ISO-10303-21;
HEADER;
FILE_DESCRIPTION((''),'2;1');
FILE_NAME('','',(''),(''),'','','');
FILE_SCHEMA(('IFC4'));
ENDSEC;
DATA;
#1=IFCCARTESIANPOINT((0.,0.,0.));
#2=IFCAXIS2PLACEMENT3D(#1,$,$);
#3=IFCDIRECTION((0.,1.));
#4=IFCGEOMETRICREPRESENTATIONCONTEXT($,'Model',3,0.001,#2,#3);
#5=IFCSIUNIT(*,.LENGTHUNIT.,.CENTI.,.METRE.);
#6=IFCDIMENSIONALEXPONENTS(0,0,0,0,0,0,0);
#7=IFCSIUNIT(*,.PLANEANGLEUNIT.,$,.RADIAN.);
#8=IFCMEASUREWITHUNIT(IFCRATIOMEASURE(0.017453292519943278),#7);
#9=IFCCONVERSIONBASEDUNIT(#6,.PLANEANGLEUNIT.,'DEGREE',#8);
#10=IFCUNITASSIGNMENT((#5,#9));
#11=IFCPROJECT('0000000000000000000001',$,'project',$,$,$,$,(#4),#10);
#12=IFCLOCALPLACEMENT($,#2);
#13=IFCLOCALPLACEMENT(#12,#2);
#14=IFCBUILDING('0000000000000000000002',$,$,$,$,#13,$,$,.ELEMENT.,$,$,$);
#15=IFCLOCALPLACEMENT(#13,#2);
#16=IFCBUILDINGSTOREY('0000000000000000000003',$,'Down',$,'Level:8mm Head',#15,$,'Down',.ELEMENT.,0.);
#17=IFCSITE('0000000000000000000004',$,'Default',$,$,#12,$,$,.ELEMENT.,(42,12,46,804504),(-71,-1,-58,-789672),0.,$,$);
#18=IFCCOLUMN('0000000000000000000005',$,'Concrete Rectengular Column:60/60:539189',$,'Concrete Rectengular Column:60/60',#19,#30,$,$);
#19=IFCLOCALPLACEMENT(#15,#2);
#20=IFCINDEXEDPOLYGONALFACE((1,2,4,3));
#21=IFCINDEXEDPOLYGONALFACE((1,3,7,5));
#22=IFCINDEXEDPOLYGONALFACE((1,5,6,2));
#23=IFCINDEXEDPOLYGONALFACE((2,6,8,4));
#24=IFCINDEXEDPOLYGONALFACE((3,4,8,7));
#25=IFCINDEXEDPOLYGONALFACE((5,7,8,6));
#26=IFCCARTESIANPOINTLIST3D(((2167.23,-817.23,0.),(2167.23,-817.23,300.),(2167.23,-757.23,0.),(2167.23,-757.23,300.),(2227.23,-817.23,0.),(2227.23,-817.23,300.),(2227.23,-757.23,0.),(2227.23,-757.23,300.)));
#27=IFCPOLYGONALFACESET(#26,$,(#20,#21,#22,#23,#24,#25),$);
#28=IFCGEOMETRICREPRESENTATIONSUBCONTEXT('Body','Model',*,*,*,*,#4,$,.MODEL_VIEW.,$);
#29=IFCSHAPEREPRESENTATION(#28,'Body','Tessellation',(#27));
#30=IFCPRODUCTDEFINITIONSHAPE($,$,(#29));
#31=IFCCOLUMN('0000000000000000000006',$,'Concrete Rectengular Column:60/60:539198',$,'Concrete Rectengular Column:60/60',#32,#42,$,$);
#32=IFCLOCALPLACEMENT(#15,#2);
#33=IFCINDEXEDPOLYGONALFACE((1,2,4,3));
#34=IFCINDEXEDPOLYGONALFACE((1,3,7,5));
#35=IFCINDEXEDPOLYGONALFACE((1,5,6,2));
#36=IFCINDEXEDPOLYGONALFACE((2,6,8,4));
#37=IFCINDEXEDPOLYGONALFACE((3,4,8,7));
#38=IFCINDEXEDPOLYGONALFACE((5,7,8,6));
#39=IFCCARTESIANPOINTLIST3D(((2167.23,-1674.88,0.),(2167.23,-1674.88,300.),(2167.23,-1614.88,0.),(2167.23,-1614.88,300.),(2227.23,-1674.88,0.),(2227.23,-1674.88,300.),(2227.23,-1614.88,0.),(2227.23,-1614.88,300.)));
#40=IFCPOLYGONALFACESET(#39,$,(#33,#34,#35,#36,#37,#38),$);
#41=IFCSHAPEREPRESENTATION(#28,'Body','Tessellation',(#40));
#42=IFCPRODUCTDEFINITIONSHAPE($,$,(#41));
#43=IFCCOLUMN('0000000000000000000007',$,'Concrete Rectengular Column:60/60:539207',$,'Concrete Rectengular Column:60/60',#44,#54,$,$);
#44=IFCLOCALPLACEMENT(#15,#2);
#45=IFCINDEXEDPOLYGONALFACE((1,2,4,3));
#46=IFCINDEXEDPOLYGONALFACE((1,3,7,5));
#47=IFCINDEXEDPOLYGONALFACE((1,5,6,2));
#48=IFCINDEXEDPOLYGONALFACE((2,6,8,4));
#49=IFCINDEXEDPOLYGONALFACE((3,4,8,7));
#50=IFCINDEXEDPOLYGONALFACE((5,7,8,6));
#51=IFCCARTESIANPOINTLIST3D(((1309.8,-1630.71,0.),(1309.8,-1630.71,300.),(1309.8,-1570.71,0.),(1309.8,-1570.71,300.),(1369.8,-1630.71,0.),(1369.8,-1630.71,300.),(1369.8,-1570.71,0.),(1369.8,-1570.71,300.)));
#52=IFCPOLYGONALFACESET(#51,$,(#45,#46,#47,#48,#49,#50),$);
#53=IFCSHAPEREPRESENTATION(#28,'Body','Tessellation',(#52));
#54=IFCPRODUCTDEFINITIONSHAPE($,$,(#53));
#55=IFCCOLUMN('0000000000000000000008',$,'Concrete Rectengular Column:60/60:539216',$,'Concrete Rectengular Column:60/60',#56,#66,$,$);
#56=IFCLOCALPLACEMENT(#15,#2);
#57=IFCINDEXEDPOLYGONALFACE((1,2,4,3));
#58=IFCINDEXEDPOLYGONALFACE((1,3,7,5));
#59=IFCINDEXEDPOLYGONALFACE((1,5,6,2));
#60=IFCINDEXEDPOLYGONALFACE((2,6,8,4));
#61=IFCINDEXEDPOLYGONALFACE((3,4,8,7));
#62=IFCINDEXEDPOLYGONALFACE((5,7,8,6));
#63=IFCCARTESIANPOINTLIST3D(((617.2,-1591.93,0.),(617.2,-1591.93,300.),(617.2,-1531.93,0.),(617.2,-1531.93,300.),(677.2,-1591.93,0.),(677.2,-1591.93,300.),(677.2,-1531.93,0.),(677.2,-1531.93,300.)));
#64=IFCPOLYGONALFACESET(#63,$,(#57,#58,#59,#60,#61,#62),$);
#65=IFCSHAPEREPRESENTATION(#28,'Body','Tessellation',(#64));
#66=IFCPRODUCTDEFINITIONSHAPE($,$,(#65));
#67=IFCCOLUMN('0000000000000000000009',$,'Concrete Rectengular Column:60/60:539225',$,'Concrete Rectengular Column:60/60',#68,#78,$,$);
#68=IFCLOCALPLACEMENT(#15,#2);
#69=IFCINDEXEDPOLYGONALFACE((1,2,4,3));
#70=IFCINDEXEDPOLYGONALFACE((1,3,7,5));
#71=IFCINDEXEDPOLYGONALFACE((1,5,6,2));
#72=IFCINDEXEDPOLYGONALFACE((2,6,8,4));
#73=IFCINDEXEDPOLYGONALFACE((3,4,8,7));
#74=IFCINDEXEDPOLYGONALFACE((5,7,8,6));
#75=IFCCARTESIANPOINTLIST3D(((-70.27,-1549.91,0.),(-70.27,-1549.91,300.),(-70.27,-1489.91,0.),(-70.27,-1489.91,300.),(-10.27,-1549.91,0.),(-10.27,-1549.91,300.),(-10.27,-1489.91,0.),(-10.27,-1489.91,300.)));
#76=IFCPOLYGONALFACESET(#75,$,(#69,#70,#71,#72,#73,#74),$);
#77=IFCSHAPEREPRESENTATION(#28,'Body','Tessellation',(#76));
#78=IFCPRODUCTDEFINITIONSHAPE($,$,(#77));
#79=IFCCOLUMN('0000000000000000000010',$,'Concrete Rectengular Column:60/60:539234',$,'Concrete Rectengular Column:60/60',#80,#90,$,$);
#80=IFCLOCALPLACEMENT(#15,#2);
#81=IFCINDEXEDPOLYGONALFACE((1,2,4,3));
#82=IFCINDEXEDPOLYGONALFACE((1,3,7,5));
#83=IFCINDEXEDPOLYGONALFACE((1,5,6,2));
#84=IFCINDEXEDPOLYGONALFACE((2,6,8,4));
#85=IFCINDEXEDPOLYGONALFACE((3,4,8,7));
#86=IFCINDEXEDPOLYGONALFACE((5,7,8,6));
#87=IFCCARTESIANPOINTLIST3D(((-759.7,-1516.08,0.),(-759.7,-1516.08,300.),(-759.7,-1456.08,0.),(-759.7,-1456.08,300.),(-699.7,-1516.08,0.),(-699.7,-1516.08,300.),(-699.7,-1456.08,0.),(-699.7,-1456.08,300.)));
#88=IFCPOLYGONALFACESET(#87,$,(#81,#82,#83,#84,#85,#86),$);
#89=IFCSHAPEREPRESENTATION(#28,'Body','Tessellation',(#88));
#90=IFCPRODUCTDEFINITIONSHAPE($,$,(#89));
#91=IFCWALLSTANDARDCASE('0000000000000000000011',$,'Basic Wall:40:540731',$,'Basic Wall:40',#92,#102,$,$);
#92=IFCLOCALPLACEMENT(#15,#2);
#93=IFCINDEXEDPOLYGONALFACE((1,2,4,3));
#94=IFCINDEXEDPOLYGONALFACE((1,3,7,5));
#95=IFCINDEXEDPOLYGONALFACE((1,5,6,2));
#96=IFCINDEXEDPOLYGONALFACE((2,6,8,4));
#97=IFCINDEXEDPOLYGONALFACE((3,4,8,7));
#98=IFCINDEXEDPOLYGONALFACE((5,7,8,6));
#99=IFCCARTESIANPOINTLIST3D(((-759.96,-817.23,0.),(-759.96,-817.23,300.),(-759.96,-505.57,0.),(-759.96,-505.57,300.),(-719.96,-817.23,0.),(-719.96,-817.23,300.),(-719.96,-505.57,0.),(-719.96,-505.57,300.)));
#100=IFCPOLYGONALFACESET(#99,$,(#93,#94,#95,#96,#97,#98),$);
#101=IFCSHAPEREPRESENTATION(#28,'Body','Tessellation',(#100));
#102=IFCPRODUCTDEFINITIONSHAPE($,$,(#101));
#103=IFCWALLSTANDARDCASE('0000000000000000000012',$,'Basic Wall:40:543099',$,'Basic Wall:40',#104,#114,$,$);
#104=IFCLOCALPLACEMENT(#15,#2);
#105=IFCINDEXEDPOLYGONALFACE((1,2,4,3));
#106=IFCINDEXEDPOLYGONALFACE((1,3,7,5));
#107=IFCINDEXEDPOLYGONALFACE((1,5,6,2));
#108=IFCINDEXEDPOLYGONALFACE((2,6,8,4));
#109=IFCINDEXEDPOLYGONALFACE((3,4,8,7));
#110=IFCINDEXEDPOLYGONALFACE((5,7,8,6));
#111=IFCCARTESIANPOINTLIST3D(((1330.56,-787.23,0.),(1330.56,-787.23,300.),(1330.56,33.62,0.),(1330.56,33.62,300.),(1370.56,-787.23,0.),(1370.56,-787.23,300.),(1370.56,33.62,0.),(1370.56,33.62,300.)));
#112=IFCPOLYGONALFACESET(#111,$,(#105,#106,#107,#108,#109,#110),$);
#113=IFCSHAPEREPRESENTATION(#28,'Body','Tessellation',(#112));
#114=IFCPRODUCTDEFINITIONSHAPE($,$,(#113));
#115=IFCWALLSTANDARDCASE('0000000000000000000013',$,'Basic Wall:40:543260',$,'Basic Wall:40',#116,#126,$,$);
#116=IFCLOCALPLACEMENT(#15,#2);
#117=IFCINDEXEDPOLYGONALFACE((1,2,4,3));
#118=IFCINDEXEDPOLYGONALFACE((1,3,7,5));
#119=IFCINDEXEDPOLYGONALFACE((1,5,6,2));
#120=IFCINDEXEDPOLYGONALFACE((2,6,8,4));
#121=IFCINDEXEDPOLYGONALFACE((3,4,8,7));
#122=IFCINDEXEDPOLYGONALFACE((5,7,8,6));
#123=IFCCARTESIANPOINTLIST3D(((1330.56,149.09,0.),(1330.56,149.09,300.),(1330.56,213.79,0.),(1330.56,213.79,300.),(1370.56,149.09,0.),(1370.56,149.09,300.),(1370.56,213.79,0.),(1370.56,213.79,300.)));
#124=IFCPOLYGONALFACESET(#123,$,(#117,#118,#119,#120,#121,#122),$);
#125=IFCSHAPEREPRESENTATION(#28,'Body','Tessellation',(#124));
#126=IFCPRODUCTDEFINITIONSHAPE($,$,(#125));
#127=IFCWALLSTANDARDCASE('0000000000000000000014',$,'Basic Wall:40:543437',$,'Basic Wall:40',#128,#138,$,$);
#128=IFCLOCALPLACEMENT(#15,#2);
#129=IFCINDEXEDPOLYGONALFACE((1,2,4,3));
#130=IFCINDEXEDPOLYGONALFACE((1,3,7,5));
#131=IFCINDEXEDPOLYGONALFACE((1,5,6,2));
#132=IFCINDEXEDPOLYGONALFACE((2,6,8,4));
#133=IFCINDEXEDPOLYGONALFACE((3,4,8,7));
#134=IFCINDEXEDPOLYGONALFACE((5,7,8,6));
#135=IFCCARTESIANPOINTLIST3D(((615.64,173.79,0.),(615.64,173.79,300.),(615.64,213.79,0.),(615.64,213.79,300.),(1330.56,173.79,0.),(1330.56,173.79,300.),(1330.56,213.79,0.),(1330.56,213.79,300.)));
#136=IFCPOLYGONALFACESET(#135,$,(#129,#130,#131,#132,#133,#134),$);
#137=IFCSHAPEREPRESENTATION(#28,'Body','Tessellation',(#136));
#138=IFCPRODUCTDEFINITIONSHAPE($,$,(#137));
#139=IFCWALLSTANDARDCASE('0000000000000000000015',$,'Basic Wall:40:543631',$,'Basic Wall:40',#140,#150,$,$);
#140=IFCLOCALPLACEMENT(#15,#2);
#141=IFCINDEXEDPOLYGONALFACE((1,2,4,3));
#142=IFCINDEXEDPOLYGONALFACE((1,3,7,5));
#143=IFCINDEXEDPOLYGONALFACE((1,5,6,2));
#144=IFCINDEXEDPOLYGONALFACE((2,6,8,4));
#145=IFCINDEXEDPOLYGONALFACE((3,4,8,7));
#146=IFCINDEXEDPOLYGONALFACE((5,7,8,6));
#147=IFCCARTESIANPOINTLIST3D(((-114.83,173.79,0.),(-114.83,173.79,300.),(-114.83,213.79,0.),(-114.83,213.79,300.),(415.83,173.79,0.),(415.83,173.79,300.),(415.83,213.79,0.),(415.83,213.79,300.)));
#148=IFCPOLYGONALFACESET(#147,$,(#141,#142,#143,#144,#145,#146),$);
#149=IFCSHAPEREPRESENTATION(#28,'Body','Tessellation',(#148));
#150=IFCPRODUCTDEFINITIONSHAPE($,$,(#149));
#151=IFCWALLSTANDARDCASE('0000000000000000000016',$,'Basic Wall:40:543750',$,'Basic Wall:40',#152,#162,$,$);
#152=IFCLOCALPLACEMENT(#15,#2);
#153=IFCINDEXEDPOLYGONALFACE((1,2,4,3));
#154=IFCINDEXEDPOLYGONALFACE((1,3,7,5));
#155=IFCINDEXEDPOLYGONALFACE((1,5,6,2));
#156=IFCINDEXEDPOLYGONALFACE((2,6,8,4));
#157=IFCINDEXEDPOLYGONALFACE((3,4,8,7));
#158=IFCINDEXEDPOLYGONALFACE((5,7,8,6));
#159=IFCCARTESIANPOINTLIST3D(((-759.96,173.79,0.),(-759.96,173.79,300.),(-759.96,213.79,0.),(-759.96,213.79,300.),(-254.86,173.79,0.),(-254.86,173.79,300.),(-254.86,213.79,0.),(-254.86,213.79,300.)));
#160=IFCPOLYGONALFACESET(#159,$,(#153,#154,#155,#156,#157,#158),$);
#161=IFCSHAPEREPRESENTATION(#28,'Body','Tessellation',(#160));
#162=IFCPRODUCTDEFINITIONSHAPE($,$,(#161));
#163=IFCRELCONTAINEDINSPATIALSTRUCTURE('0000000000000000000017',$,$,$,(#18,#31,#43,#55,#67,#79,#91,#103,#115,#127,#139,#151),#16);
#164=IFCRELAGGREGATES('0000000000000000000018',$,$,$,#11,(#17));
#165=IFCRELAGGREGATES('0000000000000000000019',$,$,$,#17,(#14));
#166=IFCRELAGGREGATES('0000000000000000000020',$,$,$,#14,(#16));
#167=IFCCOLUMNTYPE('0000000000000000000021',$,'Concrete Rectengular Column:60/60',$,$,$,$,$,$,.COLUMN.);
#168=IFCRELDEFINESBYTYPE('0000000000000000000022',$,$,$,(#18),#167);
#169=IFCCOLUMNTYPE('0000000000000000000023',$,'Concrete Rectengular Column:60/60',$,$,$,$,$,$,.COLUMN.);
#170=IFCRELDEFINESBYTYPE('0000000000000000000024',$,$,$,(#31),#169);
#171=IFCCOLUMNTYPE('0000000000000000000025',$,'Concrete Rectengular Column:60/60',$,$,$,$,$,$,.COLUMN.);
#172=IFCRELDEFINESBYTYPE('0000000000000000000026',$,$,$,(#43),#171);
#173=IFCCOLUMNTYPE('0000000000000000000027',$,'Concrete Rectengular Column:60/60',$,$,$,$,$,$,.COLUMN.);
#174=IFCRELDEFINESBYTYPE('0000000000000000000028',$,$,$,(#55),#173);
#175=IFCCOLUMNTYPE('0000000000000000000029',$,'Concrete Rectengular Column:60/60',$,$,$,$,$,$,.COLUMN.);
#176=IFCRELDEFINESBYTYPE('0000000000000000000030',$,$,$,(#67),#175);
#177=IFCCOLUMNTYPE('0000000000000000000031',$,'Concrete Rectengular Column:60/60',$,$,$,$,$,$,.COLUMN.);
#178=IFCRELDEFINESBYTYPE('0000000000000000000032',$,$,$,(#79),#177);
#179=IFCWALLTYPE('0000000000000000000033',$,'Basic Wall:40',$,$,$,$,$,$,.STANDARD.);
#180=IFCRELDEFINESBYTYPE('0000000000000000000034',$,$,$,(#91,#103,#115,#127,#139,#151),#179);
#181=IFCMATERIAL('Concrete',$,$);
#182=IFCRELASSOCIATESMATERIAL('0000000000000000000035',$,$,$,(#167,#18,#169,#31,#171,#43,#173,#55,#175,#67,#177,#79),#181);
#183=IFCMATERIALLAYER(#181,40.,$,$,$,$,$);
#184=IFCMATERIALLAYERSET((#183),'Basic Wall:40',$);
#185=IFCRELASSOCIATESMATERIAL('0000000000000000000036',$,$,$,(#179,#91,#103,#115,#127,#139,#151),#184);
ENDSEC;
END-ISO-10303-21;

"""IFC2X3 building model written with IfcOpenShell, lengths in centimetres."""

from ifc_helpers import new_model, entity, si_unit, converted_unit, direction, frame, frame_2d, origin, origin_2d_with_axis, place, context, subcontext, project, spatial, rectangle, extrude, source, transform, mapped, material, layer, layer_set, layer_usage, type_object, type_shapes, element, save


model = new_model("IFC2X3")

# Units and contexts
model_context = context("Model", 3, precision=0.001, world=origin(), true_north=direction((0.0, 1.0)))
body_context = subcontext(model_context, "Body", "Model", "MODEL_VIEW")
ifc_project = project(units=[si_unit("LENGTHUNIT", "METRE", prefix="CENTI"), converted_unit("PLANEANGLEUNIT", "DEGREE", entity("IfcRatioMeasure", 0.017453292519943278), si_unit("PLANEANGLEUNIT", "RADIAN"), dimensions=[0, 0, 0, 0, 0, 0, 0])], contexts=[model_context])

# Site, building, storey
site_placement = place(None, origin())
site = spatial("IfcSite", under=ifc_project, at=site_placement, Name="Default", CompositionType="ELEMENT", RefLatitude=(42, 12, 46, 804504), RefLongitude=(-71, -1, -58, -789672), RefElevation=0.0)
building_placement = place(site_placement, origin())
building = spatial("IfcBuilding", under=site, at=building_placement, CompositionType="ELEMENT")
storey_placement = place(building_placement, origin())
storey = spatial("IfcBuildingStorey", under=building, at=storey_placement, Name="Down", ObjectType="Level:8mm Head", LongName="Down", CompositionType="ELEMENT", Elevation=0.0)

# Columns
ifc_material = material(Name="Concrete")
column_type_1 = type_object("IfcColumnType", Name="Concrete Rectengular Column:60/60", PredefinedType="COLUMN", material=ifc_material)
shared_shape_1 = source(origin(), body_context, "Body", "SweptSolid", [
    extrude(rectangle(XDim=60.0, YDim=60.0, at=origin_2d_with_axis()), frame((2197.23, -787.23, 0.0), z_axis=(0.0, 0.0, 1.0), x_axis=(0.0, -1.0, 0.0)), (0.0, 0.0, 1.0), 300.0),
])
type_shapes(column_type_1, [shared_shape_1])
column_1_placement = place(storey_placement, origin())
element("IfcColumn", 1, at=column_1_placement, inside=storey, type_object=column_type_1, material=ifc_material, Name="Concrete Rectengular Column:60/60:539189", ObjectType="Concrete Rectengular Column:60/60", context=body_context, shape_type="MappedRepresentation", body=[
    mapped(shared_shape_1, transform((0.0, 0.0, 0.0), scale=1.0)),
])
column_type_2 = type_object("IfcColumnType", Name="Concrete Rectengular Column:60/60", PredefinedType="COLUMN", material=ifc_material)
shared_shape_2 = source(origin(), body_context, "Body", "SweptSolid", [
    extrude(rectangle(XDim=60.0, YDim=60.0, at=frame_2d((0.0, 0.0), x_axis=(1.0, 0.0))), frame((2197.23, -1644.88, 0.0), z_axis=(0.0, 0.0, 1.0), x_axis=(0.0, -1.0, 0.0)), (0.0, 0.0, 1.0), 300.0),
])
type_shapes(column_type_2, [shared_shape_2])
column_2_placement = place(storey_placement, origin())
element("IfcColumn", 2, at=column_2_placement, inside=storey, type_object=column_type_2, material=ifc_material, Name="Concrete Rectengular Column:60/60:539198", ObjectType="Concrete Rectengular Column:60/60", context=body_context, shape_type="MappedRepresentation", body=[
    mapped(shared_shape_2, transform((0.0, 0.0, 0.0), scale=1.0)),
])
column_type_3 = type_object("IfcColumnType", Name="Concrete Rectengular Column:60/60", PredefinedType="COLUMN", material=ifc_material)
shared_shape_3 = source(origin(), body_context, "Body", "SweptSolid", [
    extrude(rectangle(XDim=60.0, YDim=60.0, at=frame_2d((0.0, 0.0), x_axis=(1.0, 0.0))), frame((1339.8, -1600.71, 0.0), z_axis=(0.0, 0.0, 1.0), x_axis=(0.0, -1.0, 0.0)), (0.0, 0.0, 1.0), 300.0),
])
type_shapes(column_type_3, [shared_shape_3])
column_3_placement = place(storey_placement, origin())
element("IfcColumn", 3, at=column_3_placement, inside=storey, type_object=column_type_3, material=ifc_material, Name="Concrete Rectengular Column:60/60:539207", ObjectType="Concrete Rectengular Column:60/60", context=body_context, shape_type="MappedRepresentation", body=[
    mapped(shared_shape_3, transform((0.0, 0.0, 0.0), scale=1.0)),
])
column_type_4 = type_object("IfcColumnType", Name="Concrete Rectengular Column:60/60", PredefinedType="COLUMN", material=ifc_material)
shared_shape_4 = source(origin(), body_context, "Body", "SweptSolid", [
    extrude(rectangle(XDim=60.0, YDim=60.0, at=frame_2d((0.0, 0.0), x_axis=(1.0, 0.0))), frame((647.2, -1561.93, 0.0), z_axis=(0.0, 0.0, 1.0), x_axis=(0.0, -1.0, 0.0)), (0.0, 0.0, 1.0), 300.0),
])
type_shapes(column_type_4, [shared_shape_4])
column_4_placement = place(storey_placement, origin())
element("IfcColumn", 4, at=column_4_placement, inside=storey, type_object=column_type_4, material=ifc_material, Name="Concrete Rectengular Column:60/60:539216", ObjectType="Concrete Rectengular Column:60/60", context=body_context, shape_type="MappedRepresentation", body=[
    mapped(shared_shape_4, transform((0.0, 0.0, 0.0), scale=1.0)),
])
column_type_5 = type_object("IfcColumnType", Name="Concrete Rectengular Column:60/60", PredefinedType="COLUMN", material=ifc_material)
shared_shape_5 = source(origin(), body_context, "Body", "SweptSolid", [
    extrude(rectangle(XDim=60.0, YDim=60.0, at=frame_2d((0.0, 0.0), x_axis=(1.0, 0.0))), frame((-40.27, -1519.91, 0.0), z_axis=(0.0, 0.0, 1.0), x_axis=(0.0, -1.0, 0.0)), (0.0, 0.0, 1.0), 300.0),
])
type_shapes(column_type_5, [shared_shape_5])
column_5_placement = place(storey_placement, origin())
element("IfcColumn", 5, at=column_5_placement, inside=storey, type_object=column_type_5, material=ifc_material, Name="Concrete Rectengular Column:60/60:539225", ObjectType="Concrete Rectengular Column:60/60", context=body_context, shape_type="MappedRepresentation", body=[
    mapped(shared_shape_5, transform((0.0, 0.0, 0.0), scale=1.0)),
])
column_type_6 = type_object("IfcColumnType", Name="Concrete Rectengular Column:60/60", PredefinedType="COLUMN", material=ifc_material)
shared_shape_6 = source(origin(), body_context, "Body", "SweptSolid", [
    extrude(rectangle(XDim=60.0, YDim=60.0, at=frame_2d((0.0, 0.0), x_axis=(1.0, 0.0))), frame((-729.7, -1486.08, 0.0), z_axis=(0.0, 0.0, 1.0), x_axis=(0.0, -1.0, 0.0)), (0.0, 0.0, 1.0), 300.0),
])
type_shapes(column_type_6, [shared_shape_6])
column_6_placement = place(storey_placement, origin())
element("IfcColumn", 6, at=column_6_placement, inside=storey, type_object=column_type_6, material=ifc_material, Name="Concrete Rectengular Column:60/60:539234", ObjectType="Concrete Rectengular Column:60/60", context=body_context, shape_type="MappedRepresentation", body=[
    mapped(shared_shape_6, transform((0.0, 0.0, 0.0), scale=1.0)),
])

# Walls
ifc_layer_1 = layer(ifc_material, 40.0)
ifc_layer_set_1 = layer_set([ifc_layer_1], Name="Basic Wall:40")
ifc_layer_usage_1 = layer_usage(ifc_layer_set_1, "AXIS2", "NEGATIVE", 20.0)
wall_type_1 = type_object("IfcWallType", Name="Basic Wall:40", PredefinedType="STANDARD", material=ifc_layer_set_1)
wall_1_placement = place(storey_placement, frame((-739.96, -817.23, 0.0), z_axis=(0.0, 0.0, 1.0), x_axis=(0.0, 1.0, 0.0)))
element("IfcWallStandardCase", 7, at=wall_1_placement, inside=storey, type_object=wall_type_1, material=ifc_layer_usage_1, Name="Basic Wall:40:540731", ObjectType="Basic Wall:40", context=body_context, shape_type="SweptSolid", body=[
    extrude(rectangle(XDim=311.66, YDim=40.0, at=frame_2d((155.83, 0.0), x_axis=(-1.0, 0.0))), origin(), (0.0, 0.0, 1.0), 300.0),
])
ifc_layer_usage_2 = layer_usage(ifc_layer_set_1, "AXIS2", "POSITIVE", -20.0)
wall_2_placement = place(storey_placement, frame((1350.56, -787.23, 0.0), z_axis=(0.0, 0.0, 1.0), x_axis=(0.0, 1.0, 0.0)))
element("IfcWallStandardCase", 8, at=wall_2_placement, inside=storey, type_object=wall_type_1, material=ifc_layer_usage_2, Name="Basic Wall:40:543099", ObjectType="Basic Wall:40", context=body_context, shape_type="SweptSolid", body=[
    extrude(rectangle(XDim=820.85, YDim=40.0, at=frame_2d((410.43, 0.0), x_axis=(-1.0, 0.0))), origin(), (0.0, 0.0, 1.0), 300.0),
])
ifc_layer_usage_3 = layer_usage(ifc_layer_set_1, "AXIS2", "NEGATIVE", 20.0)
wall_3_placement = place(storey_placement, frame((1350.56, 149.09, 0.0), z_axis=(0.0, 0.0, 1.0), x_axis=(0.0, 1.0, 0.0)))
element("IfcWallStandardCase", 9, at=wall_3_placement, inside=storey, type_object=wall_type_1, material=ifc_layer_usage_3, Name="Basic Wall:40:543260", ObjectType="Basic Wall:40", context=body_context, shape_type="SweptSolid", body=[
    extrude(rectangle(XDim=64.69, YDim=40.0, at=frame_2d((32.35, 0.0), x_axis=(-1.0, 0.0))), origin(), (0.0, 0.0, 1.0), 300.0),
])
ifc_layer_usage_4 = layer_usage(ifc_layer_set_1, "AXIS2", "POSITIVE", -20.0)
wall_4_placement = place(storey_placement, frame((1330.56, 193.79, 0.0), z_axis=(0.0, 0.0, 1.0), x_axis=(-1.0, 0.0, 0.0)))
element("IfcWallStandardCase", 10, at=wall_4_placement, inside=storey, type_object=wall_type_1, material=ifc_layer_usage_4, Name="Basic Wall:40:543437", ObjectType="Basic Wall:40", context=body_context, shape_type="SweptSolid", body=[
    extrude(rectangle(XDim=714.91, YDim=40.0, at=frame_2d((357.46, 0.0), x_axis=(-1.0, 0.0))), origin(), (0.0, 0.0, 1.0), 300.0),
])
ifc_layer_usage_5 = layer_usage(ifc_layer_set_1, "AXIS2", "POSITIVE", -20.0)
wall_5_placement = place(storey_placement, frame((415.83, 193.79, 0.0), z_axis=(0.0, 0.0, 1.0), x_axis=(-1.0, 0.0, 0.0)))
element("IfcWallStandardCase", 11, at=wall_5_placement, inside=storey, type_object=wall_type_1, material=ifc_layer_usage_5, Name="Basic Wall:40:543631", ObjectType="Basic Wall:40", context=body_context, shape_type="SweptSolid", body=[
    extrude(rectangle(XDim=530.66, YDim=40.0, at=frame_2d((265.33, 0.0), x_axis=(-1.0, 0.0))), origin(), (0.0, 0.0, 1.0), 300.0),
])
ifc_layer_usage_6 = layer_usage(ifc_layer_set_1, "AXIS2", "POSITIVE", -20.0)
wall_6_placement = place(storey_placement, frame((-254.86, 193.79, 0.0), z_axis=(0.0, 0.0, 1.0), x_axis=(-1.0, 0.0, 0.0)))
element("IfcWallStandardCase", 12, at=wall_6_placement, inside=storey, type_object=wall_type_1, material=ifc_layer_usage_6, Name="Basic Wall:40:543750", ObjectType="Basic Wall:40", context=body_context, shape_type="SweptSolid", body=[
    extrude(rectangle(XDim=505.09, YDim=40.0, at=frame_2d((252.55, 0.0), x_axis=(-1.0, 0.0))), origin(), (0.0, 0.0, 1.0), 300.0),
])

save(model, "model.ifc")
